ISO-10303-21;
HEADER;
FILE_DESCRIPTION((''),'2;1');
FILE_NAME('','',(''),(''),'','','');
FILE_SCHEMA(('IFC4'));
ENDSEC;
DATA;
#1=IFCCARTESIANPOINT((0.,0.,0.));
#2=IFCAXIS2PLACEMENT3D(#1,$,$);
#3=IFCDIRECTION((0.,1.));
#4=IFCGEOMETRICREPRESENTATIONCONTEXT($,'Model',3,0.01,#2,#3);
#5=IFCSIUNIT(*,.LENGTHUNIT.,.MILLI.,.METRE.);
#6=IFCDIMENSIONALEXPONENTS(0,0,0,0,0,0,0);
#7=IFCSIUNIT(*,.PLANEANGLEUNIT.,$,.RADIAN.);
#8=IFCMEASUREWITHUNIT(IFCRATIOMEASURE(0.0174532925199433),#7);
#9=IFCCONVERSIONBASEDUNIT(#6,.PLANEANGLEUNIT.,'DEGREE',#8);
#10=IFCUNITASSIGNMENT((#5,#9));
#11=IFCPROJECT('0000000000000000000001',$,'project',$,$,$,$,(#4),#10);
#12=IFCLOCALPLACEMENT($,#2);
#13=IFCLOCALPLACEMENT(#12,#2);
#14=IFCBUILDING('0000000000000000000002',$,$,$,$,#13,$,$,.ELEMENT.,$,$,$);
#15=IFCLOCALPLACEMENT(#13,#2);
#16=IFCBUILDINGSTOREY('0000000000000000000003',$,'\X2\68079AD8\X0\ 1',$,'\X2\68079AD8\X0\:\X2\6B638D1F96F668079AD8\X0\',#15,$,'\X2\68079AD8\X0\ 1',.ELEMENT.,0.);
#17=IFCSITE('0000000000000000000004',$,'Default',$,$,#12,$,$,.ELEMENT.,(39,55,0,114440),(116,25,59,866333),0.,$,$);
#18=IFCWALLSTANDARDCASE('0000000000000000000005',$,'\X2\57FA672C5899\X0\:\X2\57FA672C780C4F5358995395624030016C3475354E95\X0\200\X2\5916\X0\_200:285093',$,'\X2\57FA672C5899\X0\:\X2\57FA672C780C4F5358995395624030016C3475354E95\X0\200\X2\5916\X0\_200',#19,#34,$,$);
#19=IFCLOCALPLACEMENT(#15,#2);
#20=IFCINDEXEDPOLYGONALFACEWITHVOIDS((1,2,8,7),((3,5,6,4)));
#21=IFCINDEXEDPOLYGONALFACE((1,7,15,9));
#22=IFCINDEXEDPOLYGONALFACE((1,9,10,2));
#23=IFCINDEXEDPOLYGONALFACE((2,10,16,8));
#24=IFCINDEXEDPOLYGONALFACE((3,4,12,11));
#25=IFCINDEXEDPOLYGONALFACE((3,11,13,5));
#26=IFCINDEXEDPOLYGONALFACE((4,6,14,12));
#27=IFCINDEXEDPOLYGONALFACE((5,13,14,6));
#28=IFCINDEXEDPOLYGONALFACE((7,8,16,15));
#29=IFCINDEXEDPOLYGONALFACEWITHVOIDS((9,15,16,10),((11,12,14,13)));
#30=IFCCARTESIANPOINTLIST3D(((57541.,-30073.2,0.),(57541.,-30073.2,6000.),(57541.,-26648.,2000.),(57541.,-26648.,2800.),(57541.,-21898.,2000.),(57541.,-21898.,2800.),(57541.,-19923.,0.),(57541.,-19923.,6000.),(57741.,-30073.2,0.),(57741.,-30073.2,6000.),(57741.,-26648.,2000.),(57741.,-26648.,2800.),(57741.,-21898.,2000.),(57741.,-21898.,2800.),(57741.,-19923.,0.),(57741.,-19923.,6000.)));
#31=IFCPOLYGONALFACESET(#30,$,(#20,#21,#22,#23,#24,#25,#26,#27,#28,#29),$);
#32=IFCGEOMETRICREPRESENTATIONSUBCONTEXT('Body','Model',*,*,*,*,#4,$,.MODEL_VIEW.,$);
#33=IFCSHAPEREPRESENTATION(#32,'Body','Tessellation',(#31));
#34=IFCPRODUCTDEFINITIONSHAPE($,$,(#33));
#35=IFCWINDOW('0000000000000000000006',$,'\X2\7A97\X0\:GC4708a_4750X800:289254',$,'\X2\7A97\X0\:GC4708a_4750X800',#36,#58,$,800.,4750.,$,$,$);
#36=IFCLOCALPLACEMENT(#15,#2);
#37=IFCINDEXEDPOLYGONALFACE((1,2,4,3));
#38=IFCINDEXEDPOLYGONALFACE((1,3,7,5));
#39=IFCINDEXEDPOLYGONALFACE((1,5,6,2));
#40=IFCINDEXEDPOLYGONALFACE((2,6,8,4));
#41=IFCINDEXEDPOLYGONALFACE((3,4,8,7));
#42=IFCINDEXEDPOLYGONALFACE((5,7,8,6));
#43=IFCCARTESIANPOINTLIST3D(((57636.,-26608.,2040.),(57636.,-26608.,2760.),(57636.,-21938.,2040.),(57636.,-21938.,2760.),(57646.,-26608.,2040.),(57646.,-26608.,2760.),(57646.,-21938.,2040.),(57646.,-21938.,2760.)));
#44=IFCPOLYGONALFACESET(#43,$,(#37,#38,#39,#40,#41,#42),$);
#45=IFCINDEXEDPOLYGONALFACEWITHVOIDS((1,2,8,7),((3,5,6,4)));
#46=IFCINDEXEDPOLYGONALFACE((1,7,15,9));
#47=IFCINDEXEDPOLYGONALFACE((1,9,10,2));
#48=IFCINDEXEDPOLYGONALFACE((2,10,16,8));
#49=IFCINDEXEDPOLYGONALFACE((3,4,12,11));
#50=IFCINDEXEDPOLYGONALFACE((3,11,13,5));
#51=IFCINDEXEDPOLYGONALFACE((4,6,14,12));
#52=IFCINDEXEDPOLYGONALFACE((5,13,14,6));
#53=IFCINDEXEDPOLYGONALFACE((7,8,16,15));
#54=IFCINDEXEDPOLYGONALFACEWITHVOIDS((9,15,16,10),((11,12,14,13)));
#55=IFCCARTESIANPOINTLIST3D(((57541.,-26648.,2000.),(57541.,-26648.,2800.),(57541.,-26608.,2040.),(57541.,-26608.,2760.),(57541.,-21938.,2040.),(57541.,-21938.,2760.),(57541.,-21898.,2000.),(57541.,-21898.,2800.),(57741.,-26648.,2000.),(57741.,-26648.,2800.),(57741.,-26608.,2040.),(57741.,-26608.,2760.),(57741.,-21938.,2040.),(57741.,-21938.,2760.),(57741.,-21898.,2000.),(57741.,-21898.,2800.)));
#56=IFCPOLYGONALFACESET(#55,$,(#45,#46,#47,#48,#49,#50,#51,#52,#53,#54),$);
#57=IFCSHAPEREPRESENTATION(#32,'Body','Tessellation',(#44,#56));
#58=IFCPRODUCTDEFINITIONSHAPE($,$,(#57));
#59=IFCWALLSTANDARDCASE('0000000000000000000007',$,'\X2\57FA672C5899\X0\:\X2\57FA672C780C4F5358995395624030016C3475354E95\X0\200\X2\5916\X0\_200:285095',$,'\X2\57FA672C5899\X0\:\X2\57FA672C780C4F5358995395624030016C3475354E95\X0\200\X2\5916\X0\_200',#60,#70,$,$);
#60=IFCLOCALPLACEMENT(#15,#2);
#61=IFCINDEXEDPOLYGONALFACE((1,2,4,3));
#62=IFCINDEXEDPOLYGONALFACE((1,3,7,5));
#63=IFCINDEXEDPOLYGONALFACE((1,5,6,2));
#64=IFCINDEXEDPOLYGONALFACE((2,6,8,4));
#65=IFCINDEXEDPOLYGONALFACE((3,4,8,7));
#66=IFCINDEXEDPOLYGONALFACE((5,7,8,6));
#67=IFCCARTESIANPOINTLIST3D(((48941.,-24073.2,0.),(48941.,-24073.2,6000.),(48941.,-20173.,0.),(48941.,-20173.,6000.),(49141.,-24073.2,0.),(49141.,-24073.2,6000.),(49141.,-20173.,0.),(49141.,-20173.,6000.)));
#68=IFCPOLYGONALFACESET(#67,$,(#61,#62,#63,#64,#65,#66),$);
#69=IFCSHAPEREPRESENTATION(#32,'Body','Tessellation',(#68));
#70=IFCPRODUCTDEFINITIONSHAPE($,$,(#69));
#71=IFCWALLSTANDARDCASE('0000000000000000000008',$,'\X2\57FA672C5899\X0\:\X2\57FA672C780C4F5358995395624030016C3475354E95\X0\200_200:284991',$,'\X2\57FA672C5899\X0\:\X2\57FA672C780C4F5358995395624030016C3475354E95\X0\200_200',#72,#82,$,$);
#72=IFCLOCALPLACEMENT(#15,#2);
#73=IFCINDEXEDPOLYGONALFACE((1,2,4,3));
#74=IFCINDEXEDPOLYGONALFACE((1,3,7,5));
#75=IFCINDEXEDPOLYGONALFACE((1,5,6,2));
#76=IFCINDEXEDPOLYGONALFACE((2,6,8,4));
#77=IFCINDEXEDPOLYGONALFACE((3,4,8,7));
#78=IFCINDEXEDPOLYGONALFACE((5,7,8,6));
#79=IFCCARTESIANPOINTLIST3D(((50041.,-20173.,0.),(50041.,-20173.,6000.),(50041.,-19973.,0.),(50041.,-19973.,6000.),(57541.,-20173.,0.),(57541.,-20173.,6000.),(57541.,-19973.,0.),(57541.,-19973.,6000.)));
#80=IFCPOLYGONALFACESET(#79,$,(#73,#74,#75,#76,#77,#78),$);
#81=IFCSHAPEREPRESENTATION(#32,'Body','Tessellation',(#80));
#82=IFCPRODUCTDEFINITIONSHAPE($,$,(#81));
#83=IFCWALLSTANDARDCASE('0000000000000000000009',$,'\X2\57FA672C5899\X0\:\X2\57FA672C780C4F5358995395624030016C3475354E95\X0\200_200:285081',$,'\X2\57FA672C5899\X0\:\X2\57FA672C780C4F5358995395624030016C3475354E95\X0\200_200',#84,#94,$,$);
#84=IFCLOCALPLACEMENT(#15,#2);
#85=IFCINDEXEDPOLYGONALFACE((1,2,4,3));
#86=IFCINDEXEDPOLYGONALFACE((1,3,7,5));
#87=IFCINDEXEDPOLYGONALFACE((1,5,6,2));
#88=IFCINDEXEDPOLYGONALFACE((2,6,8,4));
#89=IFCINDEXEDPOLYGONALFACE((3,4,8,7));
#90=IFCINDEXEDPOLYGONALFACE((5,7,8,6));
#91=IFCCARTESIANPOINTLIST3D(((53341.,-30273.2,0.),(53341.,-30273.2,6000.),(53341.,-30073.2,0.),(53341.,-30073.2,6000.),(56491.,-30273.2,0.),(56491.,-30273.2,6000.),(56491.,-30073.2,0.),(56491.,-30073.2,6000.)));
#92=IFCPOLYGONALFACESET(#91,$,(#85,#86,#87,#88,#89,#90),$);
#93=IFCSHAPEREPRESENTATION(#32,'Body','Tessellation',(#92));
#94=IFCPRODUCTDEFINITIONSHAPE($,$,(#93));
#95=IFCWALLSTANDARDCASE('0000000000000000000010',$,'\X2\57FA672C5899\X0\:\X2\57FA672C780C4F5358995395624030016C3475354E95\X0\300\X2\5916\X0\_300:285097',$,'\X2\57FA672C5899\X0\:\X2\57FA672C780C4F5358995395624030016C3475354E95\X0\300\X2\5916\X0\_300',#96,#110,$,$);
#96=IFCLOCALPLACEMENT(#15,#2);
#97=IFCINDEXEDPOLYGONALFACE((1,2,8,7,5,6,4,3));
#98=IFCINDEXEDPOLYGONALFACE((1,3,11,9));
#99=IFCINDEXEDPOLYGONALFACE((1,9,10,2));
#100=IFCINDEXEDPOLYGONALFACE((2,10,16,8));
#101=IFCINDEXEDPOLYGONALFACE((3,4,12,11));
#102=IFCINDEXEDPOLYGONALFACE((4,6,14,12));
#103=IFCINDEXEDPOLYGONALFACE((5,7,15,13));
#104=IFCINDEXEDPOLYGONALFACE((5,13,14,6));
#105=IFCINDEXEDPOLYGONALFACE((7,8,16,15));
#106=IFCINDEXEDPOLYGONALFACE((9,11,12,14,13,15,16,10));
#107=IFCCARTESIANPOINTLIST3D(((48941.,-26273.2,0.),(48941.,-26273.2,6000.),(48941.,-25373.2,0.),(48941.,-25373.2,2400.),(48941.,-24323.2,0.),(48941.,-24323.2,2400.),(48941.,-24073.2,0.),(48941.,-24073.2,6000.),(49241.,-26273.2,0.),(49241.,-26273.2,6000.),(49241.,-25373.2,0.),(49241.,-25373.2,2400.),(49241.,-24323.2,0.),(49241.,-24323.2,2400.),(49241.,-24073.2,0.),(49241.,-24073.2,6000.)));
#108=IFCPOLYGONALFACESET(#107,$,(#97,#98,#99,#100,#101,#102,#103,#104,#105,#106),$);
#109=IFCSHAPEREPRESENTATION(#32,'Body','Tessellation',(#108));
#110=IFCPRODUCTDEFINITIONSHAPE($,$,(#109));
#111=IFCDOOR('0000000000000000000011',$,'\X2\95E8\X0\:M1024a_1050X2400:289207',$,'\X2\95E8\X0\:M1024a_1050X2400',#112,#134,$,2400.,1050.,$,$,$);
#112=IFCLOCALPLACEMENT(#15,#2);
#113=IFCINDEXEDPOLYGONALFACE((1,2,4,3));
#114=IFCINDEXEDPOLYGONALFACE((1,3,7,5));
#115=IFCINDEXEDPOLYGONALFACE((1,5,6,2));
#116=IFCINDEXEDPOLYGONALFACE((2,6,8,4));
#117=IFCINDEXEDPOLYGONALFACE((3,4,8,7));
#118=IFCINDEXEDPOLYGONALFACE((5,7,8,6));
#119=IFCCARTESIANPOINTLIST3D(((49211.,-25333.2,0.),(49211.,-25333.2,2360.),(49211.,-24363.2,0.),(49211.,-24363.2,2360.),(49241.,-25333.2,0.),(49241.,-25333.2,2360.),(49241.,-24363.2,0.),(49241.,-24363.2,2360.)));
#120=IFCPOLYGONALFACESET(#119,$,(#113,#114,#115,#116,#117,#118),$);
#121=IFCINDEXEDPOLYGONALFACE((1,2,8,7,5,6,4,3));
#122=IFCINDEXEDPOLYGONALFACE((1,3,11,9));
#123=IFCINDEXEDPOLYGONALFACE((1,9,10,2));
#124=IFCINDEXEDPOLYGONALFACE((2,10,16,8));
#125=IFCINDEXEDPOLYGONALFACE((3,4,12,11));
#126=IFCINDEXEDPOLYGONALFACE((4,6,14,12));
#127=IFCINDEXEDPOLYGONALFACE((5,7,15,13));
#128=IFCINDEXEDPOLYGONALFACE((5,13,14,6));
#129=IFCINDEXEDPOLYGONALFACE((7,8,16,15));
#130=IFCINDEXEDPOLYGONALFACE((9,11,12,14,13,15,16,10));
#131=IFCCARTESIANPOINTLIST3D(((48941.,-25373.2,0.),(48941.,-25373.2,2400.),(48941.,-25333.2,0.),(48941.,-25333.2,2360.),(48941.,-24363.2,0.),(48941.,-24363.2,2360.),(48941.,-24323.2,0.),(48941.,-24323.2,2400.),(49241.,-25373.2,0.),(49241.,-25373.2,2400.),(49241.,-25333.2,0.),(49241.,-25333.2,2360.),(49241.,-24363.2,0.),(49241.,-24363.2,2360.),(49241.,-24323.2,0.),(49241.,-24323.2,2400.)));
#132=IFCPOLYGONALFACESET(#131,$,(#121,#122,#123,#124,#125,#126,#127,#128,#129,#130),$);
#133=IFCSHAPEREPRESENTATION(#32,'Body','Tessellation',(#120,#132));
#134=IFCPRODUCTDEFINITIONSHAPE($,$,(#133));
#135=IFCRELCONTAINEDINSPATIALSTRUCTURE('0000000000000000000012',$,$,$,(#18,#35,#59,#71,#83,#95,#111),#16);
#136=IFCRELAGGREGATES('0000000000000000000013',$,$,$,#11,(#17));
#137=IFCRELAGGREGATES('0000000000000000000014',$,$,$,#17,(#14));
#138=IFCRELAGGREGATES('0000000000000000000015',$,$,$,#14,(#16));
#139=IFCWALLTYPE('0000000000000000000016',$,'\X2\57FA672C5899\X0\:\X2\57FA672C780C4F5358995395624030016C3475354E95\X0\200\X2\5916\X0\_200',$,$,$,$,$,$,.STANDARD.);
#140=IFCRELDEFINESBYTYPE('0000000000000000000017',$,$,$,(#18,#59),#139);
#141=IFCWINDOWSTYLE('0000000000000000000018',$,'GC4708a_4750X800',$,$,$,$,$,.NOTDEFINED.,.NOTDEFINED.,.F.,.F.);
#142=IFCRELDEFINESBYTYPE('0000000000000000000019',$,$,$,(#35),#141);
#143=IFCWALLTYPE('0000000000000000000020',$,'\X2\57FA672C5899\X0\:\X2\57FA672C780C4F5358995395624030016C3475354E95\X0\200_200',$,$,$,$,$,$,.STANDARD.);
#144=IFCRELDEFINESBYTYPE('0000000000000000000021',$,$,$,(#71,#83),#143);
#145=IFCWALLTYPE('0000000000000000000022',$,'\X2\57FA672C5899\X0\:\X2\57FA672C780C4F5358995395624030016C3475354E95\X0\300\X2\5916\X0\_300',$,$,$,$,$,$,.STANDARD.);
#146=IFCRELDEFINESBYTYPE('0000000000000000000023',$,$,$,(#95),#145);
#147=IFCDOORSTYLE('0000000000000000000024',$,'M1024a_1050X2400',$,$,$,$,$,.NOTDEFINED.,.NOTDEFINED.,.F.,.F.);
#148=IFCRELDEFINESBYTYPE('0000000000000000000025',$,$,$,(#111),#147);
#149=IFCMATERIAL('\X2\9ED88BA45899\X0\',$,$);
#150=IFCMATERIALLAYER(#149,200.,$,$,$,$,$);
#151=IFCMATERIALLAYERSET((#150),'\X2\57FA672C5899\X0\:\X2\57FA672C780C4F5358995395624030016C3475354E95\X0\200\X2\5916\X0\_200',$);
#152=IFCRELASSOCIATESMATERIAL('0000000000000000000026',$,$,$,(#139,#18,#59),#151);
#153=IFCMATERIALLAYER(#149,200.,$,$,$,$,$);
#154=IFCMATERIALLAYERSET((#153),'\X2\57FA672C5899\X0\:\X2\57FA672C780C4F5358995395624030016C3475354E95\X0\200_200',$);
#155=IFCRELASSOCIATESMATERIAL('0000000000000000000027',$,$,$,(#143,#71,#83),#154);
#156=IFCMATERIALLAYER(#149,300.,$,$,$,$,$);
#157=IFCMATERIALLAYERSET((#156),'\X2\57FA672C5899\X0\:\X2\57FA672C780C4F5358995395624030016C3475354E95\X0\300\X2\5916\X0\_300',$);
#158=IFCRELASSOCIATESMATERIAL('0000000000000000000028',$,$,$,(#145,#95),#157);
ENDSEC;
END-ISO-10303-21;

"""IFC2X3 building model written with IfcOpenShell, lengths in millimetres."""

from ifc_helpers import new_model, entity, si_unit, converted_unit, direction, frame, frame_2d, origin, origin_2d_with_axis, place, context, subcontext, project, spatial, polyline, rectangle, outline, extrude, source, transform, mapped, material, layer, layer_set, layer_usage, type_object, type_shapes, element, fill, save


model = new_model("IFC2X3")

# Units and contexts
model_context = context("Model", 3, precision=0.01, world=origin(), true_north=direction((0.0, 1.0)))
body_context = subcontext(model_context, "Body", "Model", "MODEL_VIEW")
ifc_project = project(units=[si_unit("LENGTHUNIT", "METRE", prefix="MILLI"), converted_unit("PLANEANGLEUNIT", "DEGREE", entity("IfcRatioMeasure", 0.0174532925199433), si_unit("PLANEANGLEUNIT", "RADIAN"), dimensions=[0, 0, 0, 0, 0, 0, 0])], contexts=[model_context])

# Site, building, storey
site_placement = place(None, origin())
site = spatial("IfcSite", under=ifc_project, at=site_placement, Name="Default", CompositionType="ELEMENT", RefLatitude=(39, 55, 0, 114440), RefLongitude=(116, 25, 59, 866333), RefElevation=0.0)
building_placement = place(site_placement, origin())
building = spatial("IfcBuilding", under=site, at=building_placement, CompositionType="ELEMENT")
storey_placement = place(building_placement, origin())
storey = spatial("IfcBuildingStorey", under=building, at=storey_placement, Name="标高 1", ObjectType="标高:正负零标高", LongName="标高 1", CompositionType="ELEMENT", Elevation=0.0)

# Shared definitions
ifc_material = material(Name="默认墙")
ifc_layer_1 = layer(ifc_material, 200.0)
ifc_layer_set_1 = layer_set([ifc_layer_1], Name="基本墙:基本砌体墙厕所、水电井200外_200")
wall_type_1 = type_object("IfcWallType", Name="基本墙:基本砌体墙厕所、水电井200外_200", PredefinedType="STANDARD", material=ifc_layer_set_1)

# Wall, opening, window
ifc_layer_usage_1 = layer_usage(ifc_layer_set_1, "AXIS2", "NEGATIVE", 100.0)
wall_1_placement = place(building_placement, frame((57641.0, -19923.0, 0.0), z_axis=(0.0, 0.0, 1.0), x_axis=(0.0, -1.0, 0.0)))
wall_1 = element("IfcWallStandardCase", 1, at=wall_1_placement, inside=storey, type_object=wall_type_1, material=ifc_layer_usage_1, Name="基本墙:基本砌体墙厕所、水电井200外_200:285093", ObjectType="基本墙:基本砌体墙厕所、水电井200外_200", context=body_context, shape_type="SweptSolid", body=[
    extrude(rectangle(XDim=10150.2, YDim=200.0, at=frame_2d((5075.1, 0.0), x_axis=(-1.0, 0.0))), origin(), (0.0, 0.0, 1.0), 6000.0),
])
opening_1_placement = place(wall_1_placement, frame((1975.0, -100.0, 2000.0)))
opening_1 = element("IfcOpeningElement", 2, at=opening_1_placement, cuts=wall_1, ObjectType="Opening", context=body_context, shape_type="SweptSolid", body=[
    extrude(rectangle(XDim=800.0, YDim=4750.0, at=frame_2d((400.0, 2375.0), x_axis=(1.0, 0.0))), frame((0.0, 0.0, 0.0), z_axis=(0.0, 1.0, 0.0), x_axis=(0.0, 0.0, 1.0)), (0.0, 0.0, 1.0), 200.0),
])
window_style = type_object("IfcWindowStyle", Name="GC4708a_4750X800", ConstructionType="NOTDEFINED", OperationType="NOTDEFINED", ParameterTakesPrecedence=False, Sizeable=False)
shared_shape_1 = source(origin(), body_context, "Body", "SweptSolid", [
    extrude(rectangle(XDim=10.0, YDim=4670.0, at=origin_2d_with_axis()), frame((2375.0, -800.0, 40.0), z_axis=(0.0, 0.0, 1.0), x_axis=(0.0, 1.0, 0.0)), (0.0, 0.0, 1.0), 720.0),
    extrude(outline(polyline([(-2375.0, -400.0), (2375.0, -400.0), (2375.0, 400.0), (-2375.0, 400.0), (-2375.0, -400.0)]), holes=[polyline([(2335.0, 360.0), (2335.0, -360.0), (-2335.0, -360.0), (-2335.0, 360.0), (2335.0, 360.0)])]), frame((2375.0, -900.0, 400.0), z_axis=(0.0, 1.0, 0.0), x_axis=(-1.0, 0.0, 0.0)), (0.0, 0.0, 1.0), 200.0),
])
type_shapes(window_style, [shared_shape_1])
window_placement = place(opening_1_placement, frame((0.0, 900.0, 0.0)))
window = element("IfcWindow", 3, at=window_placement, inside=storey, type_object=window_style, Name="窗:GC4708a_4750X800:289254", ObjectType="窗:GC4708a_4750X800", OverallHeight=800.0, OverallWidth=4750.0, context=body_context, shape_type="MappedRepresentation", body=[
    mapped(shared_shape_1, transform((0.0, 0.0, 0.0), scale=1.0)),
])
fill(opening_1, window)

# Walls
ifc_layer_usage_2 = layer_usage(ifc_layer_set_1, "AXIS2", "NEGATIVE", 100.0)
wall_2_placement = place(building_placement, frame((49041.0, -24073.2, 0.0), z_axis=(0.0, 0.0, 1.0), x_axis=(0.0, 1.0, 0.0)))
element("IfcWallStandardCase", 4, at=wall_2_placement, inside=storey, type_object=wall_type_1, material=ifc_layer_usage_2, Name="基本墙:基本砌体墙厕所、水电井200外_200:285095", ObjectType="基本墙:基本砌体墙厕所、水电井200外_200", context=body_context, shape_type="SweptSolid", body=[
    extrude(rectangle(XDim=3900.2, YDim=200.0, at=frame_2d((1950.1, 0.0), x_axis=(-1.0, 0.0))), origin(), (0.0, 0.0, 1.0), 6000.0),
])
ifc_layer_2 = layer(ifc_material, 200.0)
ifc_layer_set_2 = layer_set([ifc_layer_2], Name="基本墙:基本砌体墙厕所、水电井200_200")
ifc_layer_usage_3 = layer_usage(ifc_layer_set_2, "AXIS2", "NEGATIVE", 100.0)
wall_type_2 = type_object("IfcWallType", Name="基本墙:基本砌体墙厕所、水电井200_200", PredefinedType="STANDARD", material=ifc_layer_set_2)
wall_3_placement = place(building_placement, frame((50041.0, -20073.0, 0.0)))
element("IfcWallStandardCase", 5, at=wall_3_placement, inside=storey, type_object=wall_type_2, material=ifc_layer_usage_3, Name="基本墙:基本砌体墙厕所、水电井200_200:284991", ObjectType="基本墙:基本砌体墙厕所、水电井200_200", context=body_context, shape_type="SweptSolid", body=[
    extrude(rectangle(XDim=7500.0, YDim=200.0, at=frame_2d((3750.0, 0.0), x_axis=(-1.0, 0.0))), origin(), (0.0, 0.0, 1.0), 6000.0),
])
ifc_layer_usage_4 = layer_usage(ifc_layer_set_2, "AXIS2", "NEGATIVE", 100.0)
wall_4_placement = place(building_placement, frame((53341.0, -30173.2, 0.0)))
element("IfcWallStandardCase", 6, at=wall_4_placement, inside=storey, type_object=wall_type_2, material=ifc_layer_usage_4, Name="基本墙:基本砌体墙厕所、水电井200_200:285081", ObjectType="基本墙:基本砌体墙厕所、水电井200_200", context=body_context, shape_type="SweptSolid", body=[
    extrude(rectangle(XDim=3150.0, YDim=200.0, at=frame_2d((1575.0, 0.0), x_axis=(-1.0, 0.0))), origin(), (0.0, 0.0, 1.0), 6000.0),
])

# Wall, opening, door
ifc_layer_3 = layer(ifc_material, 300.0)
ifc_layer_set_3 = layer_set([ifc_layer_3], Name="基本墙:基本砌体墙厕所、水电井300外_300")
ifc_layer_usage_5 = layer_usage(ifc_layer_set_3, "AXIS2", "NEGATIVE", 150.0)
wall_type_3 = type_object("IfcWallType", Name="基本墙:基本砌体墙厕所、水电井300外_300", PredefinedType="STANDARD", material=ifc_layer_set_3)
wall_5_placement = place(building_placement, frame((49091.0, -24073.2, 0.0), z_axis=(0.0, 0.0, 1.0), x_axis=(0.0, -1.0, 0.0)))
wall_5 = element("IfcWallStandardCase", 7, at=wall_5_placement, inside=storey, type_object=wall_type_3, material=ifc_layer_usage_5, Name="基本墙:基本砌体墙厕所、水电井300外_300:285097", ObjectType="基本墙:基本砌体墙厕所、水电井300外_300", context=body_context, shape_type="SweptSolid", body=[
    extrude(rectangle(XDim=2200.0, YDim=300.0, at=frame_2d((1100.0, 0.0), x_axis=(-1.0, 0.0))), origin(), (0.0, 0.0, 1.0), 6000.0),
])
opening_2_placement = place(wall_5_placement, frame((250.0, -150.0, 0.0)))
opening_2 = element("IfcOpeningElement", 8, at=opening_2_placement, cuts=wall_5, ObjectType="Opening", context=body_context, shape_type="SweptSolid", body=[
    extrude(rectangle(XDim=2400.0, YDim=1050.0, at=frame_2d((1200.0, 525.0), x_axis=(1.0, 0.0))), frame((0.0, 0.0, 0.0), z_axis=(0.0, 1.0, 0.0), x_axis=(0.0, 0.0, 1.0)), (0.0, 0.0, 1.0), 300.0),
])
door_style_1 = type_object("IfcDoorStyle", Name="M1024a_1050X2400", ConstructionType="NOTDEFINED", OperationType="NOTDEFINED", ParameterTakesPrecedence=False, Sizeable=False)
shared_shape_2 = source(origin(), body_context, "Body", "SweptSolid", [
    extrude(rectangle(XDim=30.0, YDim=970.0, at=frame_2d((0.0, 0.0), x_axis=(1.0, 0.0))), frame((525.0, -665.0, 0.0), z_axis=(0.0, 0.0, 1.0), x_axis=(0.0, 1.0, 0.0)), (0.0, 0.0, 1.0), 2360.0),
    extrude(outline(polyline([(-1170.0, 485.0), (1190.0, 485.0), (1190.0, 525.0), (-1210.0, 525.0), (-1210.0, -525.0), (1190.0, -525.0), (1190.0, -485.0), (-1170.0, -485.0), (-1170.0, 485.0)])), frame((525.0, -950.0, 1190.0), z_axis=(0.0, 1.0, 0.0), x_axis=(0.0, 0.0, -1.0)), (0.0, 0.0, 1.0), 300.0),
])
type_shapes(door_style_1, [shared_shape_2])
door_1_placement = place(opening_2_placement, frame((0.0, 950.0, 0.0)))
door_1 = element("IfcDoor", 9, at=door_1_placement, inside=storey, type_object=door_style_1, Name="门:M1024a_1050X2400:289207", ObjectType="门:M1024a_1050X2400", OverallHeight=2400.0, OverallWidth=1050.0, context=body_context, shape_type="MappedRepresentation", body=[
    mapped(shared_shape_2, transform((0.0, 0.0, 0.0), scale=1.0)),
])
fill(opening_2, door_1)

save(model, "model.ifc")
